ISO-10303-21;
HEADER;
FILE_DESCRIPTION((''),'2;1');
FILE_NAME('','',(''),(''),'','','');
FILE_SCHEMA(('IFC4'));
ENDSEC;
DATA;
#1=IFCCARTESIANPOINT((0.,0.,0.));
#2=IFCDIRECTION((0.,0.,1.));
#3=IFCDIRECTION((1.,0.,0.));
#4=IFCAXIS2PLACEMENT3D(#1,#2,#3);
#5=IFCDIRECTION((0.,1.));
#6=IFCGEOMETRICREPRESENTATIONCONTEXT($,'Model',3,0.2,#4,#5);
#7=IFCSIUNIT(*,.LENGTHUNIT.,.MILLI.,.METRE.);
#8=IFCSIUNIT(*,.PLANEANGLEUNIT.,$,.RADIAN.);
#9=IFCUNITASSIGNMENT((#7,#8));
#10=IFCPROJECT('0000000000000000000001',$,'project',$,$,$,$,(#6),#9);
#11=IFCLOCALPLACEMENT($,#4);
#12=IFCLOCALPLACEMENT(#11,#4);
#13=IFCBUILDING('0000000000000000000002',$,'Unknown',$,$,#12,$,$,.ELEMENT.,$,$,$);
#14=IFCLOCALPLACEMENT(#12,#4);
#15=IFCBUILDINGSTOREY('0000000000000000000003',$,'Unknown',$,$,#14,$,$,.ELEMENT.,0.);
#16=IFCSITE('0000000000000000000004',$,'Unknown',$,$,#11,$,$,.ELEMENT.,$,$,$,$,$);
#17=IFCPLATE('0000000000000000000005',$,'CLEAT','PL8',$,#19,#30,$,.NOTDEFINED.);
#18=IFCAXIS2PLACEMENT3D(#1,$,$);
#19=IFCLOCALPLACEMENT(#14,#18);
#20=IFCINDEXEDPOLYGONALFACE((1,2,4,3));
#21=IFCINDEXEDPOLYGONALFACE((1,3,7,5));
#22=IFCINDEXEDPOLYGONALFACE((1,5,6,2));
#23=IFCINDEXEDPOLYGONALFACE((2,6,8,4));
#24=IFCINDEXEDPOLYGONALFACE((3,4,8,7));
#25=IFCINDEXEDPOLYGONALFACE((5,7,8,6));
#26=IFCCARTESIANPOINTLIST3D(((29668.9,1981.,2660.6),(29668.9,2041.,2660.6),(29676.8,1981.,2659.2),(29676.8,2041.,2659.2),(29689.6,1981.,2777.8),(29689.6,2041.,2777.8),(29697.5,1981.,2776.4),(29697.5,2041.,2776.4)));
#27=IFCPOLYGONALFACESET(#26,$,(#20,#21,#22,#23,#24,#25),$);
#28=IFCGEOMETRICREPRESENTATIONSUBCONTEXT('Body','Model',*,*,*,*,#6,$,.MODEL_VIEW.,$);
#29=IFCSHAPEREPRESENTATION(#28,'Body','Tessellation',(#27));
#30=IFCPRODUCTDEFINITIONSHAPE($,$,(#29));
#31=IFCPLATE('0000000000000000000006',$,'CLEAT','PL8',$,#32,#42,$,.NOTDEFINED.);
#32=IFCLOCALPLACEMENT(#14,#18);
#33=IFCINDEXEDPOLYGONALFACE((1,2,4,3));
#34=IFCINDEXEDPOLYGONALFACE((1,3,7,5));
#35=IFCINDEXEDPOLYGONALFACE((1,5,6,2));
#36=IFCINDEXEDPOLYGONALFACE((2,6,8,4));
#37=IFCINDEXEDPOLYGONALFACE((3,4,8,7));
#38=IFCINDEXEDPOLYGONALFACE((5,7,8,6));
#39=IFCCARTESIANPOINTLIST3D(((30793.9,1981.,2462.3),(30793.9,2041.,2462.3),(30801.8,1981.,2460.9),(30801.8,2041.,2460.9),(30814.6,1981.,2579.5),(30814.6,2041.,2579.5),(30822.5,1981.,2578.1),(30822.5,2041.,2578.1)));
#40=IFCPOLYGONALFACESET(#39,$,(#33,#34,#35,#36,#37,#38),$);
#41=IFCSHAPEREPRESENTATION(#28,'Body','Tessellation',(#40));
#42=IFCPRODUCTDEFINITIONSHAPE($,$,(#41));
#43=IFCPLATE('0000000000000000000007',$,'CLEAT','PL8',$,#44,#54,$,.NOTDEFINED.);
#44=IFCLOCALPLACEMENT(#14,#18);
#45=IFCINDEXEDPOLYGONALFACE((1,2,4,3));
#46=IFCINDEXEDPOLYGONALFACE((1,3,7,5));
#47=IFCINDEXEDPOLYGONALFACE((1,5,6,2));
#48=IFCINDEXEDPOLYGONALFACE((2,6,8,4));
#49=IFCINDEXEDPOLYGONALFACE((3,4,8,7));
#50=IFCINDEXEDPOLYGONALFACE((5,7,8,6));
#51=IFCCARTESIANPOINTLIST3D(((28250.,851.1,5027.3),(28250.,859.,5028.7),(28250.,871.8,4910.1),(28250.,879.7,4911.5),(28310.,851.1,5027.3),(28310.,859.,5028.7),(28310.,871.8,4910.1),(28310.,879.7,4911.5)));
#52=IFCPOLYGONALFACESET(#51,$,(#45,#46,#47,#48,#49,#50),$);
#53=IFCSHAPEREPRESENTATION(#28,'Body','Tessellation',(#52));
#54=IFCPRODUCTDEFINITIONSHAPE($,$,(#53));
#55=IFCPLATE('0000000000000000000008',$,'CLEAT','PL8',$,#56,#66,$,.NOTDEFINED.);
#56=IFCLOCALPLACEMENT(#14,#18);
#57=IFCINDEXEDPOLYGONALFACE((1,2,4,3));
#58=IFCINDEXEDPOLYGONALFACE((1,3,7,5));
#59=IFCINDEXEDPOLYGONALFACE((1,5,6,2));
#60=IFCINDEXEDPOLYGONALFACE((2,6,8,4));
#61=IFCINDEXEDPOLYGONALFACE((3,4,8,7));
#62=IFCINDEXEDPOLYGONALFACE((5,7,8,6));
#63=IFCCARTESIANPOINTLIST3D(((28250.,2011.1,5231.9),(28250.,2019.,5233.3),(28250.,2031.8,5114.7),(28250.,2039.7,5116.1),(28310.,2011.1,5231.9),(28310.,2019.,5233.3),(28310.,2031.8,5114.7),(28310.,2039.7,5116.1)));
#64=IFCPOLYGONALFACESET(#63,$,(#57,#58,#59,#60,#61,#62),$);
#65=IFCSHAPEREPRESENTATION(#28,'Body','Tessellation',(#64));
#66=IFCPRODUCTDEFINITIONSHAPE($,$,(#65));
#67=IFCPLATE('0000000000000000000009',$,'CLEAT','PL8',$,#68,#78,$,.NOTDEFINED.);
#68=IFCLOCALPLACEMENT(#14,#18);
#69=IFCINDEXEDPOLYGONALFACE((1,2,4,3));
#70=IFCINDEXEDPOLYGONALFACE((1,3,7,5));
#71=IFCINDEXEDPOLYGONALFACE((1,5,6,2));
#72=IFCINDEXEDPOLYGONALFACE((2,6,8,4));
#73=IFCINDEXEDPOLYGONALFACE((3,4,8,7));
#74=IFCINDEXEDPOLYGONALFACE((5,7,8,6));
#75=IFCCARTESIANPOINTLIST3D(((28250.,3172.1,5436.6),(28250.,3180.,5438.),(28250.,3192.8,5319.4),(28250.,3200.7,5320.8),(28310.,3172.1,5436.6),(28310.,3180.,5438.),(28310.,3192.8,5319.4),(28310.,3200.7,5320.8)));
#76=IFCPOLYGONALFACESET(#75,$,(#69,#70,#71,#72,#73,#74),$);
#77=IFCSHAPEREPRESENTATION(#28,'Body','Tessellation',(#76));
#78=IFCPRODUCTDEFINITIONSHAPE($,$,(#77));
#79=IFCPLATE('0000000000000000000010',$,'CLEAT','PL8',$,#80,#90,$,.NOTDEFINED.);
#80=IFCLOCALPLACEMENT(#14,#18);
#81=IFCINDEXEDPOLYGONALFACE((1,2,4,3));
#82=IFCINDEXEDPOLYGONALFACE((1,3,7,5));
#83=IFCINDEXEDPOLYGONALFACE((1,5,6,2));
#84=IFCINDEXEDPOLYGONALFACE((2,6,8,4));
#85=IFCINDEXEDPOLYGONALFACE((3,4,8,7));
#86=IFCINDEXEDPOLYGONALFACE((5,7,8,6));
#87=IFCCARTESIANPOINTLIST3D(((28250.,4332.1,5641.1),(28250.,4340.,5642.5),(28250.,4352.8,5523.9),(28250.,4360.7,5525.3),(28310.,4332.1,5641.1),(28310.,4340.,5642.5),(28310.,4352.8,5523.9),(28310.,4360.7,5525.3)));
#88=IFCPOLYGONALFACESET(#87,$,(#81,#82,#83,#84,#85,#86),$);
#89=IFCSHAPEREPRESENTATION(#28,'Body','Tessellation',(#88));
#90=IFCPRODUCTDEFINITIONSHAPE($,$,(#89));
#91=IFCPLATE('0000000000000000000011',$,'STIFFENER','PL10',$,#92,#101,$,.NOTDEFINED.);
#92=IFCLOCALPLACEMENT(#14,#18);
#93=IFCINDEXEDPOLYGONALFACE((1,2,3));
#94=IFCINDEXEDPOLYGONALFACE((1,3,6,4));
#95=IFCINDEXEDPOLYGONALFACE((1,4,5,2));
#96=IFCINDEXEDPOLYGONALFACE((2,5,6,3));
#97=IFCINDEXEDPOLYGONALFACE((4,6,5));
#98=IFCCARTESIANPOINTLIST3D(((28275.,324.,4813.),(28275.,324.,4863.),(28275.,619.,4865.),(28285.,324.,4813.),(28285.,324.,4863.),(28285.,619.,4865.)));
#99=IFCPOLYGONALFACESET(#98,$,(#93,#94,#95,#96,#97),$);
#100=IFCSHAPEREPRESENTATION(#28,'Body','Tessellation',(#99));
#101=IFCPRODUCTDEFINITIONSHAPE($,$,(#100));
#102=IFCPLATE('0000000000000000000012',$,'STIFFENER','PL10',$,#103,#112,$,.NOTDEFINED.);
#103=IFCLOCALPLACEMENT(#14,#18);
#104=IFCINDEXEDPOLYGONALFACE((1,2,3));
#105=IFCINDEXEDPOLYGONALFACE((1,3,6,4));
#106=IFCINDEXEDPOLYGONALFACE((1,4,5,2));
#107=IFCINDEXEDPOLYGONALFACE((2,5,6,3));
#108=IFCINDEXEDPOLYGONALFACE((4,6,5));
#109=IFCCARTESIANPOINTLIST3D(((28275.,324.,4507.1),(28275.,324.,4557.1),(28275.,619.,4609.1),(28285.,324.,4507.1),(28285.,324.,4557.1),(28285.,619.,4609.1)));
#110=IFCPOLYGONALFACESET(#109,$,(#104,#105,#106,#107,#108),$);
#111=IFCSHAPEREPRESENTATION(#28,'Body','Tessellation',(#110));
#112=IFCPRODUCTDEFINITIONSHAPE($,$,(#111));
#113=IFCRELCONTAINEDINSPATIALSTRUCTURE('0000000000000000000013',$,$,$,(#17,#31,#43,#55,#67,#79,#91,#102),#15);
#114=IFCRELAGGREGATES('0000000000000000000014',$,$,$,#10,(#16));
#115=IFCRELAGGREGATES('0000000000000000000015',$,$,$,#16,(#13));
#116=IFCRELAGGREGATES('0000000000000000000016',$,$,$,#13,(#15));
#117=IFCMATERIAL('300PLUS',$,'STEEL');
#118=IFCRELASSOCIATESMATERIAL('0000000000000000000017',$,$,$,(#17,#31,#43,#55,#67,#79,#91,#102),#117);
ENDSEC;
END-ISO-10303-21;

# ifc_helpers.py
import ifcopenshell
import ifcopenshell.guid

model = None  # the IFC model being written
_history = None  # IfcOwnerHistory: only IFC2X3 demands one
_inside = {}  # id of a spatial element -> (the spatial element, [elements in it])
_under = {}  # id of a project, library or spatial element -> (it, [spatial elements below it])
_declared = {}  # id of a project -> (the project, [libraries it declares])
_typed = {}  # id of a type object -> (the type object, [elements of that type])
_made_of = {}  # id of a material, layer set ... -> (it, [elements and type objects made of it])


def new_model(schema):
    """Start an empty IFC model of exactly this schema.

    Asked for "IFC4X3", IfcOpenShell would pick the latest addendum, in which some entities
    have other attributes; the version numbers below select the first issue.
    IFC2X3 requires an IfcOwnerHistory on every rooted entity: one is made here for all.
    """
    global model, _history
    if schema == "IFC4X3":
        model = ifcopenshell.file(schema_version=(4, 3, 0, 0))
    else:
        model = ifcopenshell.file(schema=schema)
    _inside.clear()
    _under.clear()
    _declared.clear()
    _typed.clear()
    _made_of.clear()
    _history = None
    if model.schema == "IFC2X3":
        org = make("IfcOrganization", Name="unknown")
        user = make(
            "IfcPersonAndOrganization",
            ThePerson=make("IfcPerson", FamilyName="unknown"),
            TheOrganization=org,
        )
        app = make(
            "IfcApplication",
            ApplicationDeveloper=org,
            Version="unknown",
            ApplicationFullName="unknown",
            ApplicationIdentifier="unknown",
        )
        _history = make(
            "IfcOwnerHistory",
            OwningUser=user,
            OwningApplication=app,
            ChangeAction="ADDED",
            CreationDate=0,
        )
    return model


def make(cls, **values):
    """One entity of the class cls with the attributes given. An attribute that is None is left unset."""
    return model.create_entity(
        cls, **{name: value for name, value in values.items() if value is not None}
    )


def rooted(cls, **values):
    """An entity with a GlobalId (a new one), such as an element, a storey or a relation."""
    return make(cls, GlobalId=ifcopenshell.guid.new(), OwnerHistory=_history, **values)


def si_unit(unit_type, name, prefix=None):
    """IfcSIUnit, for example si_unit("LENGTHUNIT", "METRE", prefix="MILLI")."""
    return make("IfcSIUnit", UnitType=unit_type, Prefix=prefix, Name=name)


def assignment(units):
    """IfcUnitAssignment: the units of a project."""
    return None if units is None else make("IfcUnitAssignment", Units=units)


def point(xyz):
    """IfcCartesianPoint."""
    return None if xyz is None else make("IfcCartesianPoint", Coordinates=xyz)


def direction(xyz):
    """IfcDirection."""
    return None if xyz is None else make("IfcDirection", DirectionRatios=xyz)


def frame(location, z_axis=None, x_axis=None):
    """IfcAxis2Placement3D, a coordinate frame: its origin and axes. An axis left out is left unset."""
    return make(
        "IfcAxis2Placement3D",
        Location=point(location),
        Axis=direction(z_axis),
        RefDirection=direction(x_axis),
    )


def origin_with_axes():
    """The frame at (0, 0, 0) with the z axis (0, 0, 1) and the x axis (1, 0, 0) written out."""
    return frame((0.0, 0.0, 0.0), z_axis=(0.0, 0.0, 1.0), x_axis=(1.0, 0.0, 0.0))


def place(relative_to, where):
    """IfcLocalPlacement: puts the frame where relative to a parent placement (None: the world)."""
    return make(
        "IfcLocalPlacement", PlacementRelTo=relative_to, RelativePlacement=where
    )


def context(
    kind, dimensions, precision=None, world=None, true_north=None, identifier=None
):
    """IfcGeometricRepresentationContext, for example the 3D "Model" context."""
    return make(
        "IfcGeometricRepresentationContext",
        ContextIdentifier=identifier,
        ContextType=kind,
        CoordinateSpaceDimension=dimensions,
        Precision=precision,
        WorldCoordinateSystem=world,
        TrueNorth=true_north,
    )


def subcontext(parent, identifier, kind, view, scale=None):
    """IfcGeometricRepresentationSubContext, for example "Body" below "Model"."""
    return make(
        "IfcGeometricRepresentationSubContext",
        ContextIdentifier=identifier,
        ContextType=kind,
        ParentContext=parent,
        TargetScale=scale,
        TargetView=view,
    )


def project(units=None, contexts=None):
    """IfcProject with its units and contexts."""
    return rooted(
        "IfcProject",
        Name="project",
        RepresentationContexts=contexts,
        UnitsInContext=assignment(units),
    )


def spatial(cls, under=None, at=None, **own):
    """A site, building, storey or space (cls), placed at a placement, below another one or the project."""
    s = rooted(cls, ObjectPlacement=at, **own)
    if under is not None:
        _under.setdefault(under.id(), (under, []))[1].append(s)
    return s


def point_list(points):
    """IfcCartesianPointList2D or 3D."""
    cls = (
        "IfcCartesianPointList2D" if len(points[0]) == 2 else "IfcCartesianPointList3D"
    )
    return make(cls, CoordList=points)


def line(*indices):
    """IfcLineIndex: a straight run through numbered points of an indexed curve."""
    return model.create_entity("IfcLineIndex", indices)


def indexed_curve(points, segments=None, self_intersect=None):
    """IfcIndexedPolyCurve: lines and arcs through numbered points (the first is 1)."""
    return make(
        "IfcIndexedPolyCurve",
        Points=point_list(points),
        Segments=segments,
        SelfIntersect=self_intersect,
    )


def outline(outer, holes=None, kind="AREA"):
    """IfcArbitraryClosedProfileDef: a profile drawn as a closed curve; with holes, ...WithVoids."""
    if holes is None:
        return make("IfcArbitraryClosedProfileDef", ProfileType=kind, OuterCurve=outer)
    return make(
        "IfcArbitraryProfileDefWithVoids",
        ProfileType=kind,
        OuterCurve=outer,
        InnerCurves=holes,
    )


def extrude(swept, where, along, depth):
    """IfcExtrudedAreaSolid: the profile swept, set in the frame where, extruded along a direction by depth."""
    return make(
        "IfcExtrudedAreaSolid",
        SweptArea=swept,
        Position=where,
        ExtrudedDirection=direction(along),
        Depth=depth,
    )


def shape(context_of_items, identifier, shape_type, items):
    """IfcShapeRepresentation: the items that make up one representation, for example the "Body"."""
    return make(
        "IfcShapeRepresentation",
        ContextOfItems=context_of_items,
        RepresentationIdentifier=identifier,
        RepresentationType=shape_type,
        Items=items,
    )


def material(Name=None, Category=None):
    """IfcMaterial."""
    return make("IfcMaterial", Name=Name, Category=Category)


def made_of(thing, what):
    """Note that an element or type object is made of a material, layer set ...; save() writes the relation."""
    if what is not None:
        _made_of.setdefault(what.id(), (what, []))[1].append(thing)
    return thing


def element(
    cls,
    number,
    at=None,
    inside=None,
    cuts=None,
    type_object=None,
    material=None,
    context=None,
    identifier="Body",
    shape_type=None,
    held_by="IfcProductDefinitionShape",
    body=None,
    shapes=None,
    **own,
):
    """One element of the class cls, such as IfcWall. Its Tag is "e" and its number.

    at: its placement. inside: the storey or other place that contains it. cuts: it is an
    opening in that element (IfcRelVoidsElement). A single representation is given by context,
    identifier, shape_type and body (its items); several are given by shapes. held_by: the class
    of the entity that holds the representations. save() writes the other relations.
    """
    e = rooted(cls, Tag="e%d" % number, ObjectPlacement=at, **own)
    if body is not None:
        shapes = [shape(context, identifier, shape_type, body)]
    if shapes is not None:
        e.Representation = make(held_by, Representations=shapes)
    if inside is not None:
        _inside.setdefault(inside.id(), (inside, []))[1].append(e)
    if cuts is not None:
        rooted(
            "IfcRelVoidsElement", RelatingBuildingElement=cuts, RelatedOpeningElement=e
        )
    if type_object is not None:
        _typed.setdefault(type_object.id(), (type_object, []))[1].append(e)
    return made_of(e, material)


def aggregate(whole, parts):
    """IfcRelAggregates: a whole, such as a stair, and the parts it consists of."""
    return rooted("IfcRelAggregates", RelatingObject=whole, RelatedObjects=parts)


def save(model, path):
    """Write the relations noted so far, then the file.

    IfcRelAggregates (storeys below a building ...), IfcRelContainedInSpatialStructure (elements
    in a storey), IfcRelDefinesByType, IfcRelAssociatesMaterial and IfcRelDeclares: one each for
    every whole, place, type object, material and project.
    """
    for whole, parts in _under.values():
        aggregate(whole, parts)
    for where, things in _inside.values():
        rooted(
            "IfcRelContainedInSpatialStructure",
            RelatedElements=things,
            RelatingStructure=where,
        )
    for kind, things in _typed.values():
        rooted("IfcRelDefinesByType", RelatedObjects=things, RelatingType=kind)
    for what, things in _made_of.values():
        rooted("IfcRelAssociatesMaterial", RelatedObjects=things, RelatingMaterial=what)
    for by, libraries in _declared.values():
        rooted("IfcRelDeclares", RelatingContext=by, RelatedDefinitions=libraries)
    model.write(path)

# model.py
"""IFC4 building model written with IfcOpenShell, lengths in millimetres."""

from ifc_helpers import new_model, si_unit, direction, frame, origin_with_axes, place, context, subcontext, project, spatial, line, indexed_curve, outline, extrude, material, element, save


model = new_model("IFC4")

# Units and contexts
model_context = context("Model", 3, precision=0.2, world=origin_with_axes(), true_north=direction((0.0, 1.0)))
body_context = subcontext(model_context, "Body", "Model", "MODEL_VIEW")
ifc_project = project(units=[si_unit("LENGTHUNIT", "METRE", prefix="MILLI"), si_unit("PLANEANGLEUNIT", "RADIAN")], contexts=[model_context])

# Site, building, storey
site_placement = place(None, origin_with_axes())
site = spatial("IfcSite", under=ifc_project, at=site_placement, Name="Unknown", CompositionType="ELEMENT")
building_placement = place(site_placement, origin_with_axes())
building = spatial("IfcBuilding", under=site, at=building_placement, Name="Unknown", CompositionType="ELEMENT")
storey_placement = place(building_placement, origin_with_axes())
storey = spatial("IfcBuildingStorey", under=building, at=storey_placement, Name="Unknown", CompositionType="ELEMENT", Elevation=0.0)

# Shared definitions
ifc_material_1 = material(Name="300PLUS", Category="STEEL")

# Plates
for number, where, z_axis, x_axis, name in (
    (1, (29672.9, 2041.0, 2659.9), (-0.984758, 0.0, 0.173929), (0.0, -1.0, 0.0), "CLEAT"),
    (2, (30797.9, 2041.0, 2461.6), (-0.984758, 0.0, 0.173929), (0.0, -1.0, 0.0), "CLEAT"),
    (3, (28310.0, 875.7, 4910.8), (0.0, 0.984758, 0.173929), (-1.0, 0.0, 0.0), "CLEAT"),
    (4, (28310.0, 2035.7, 5115.4), (0.0, 0.984758, 0.173929), (-1.0, 0.0, 0.0), "CLEAT"),
    (5, (28310.0, 3196.7, 5320.1), (0.0, 0.984758, 0.173929), (-1.0, 0.0, 0.0), "CLEAT"),
    (6, (28310.0, 4356.7, 5524.6), (0.0, 0.984758, 0.173929), (-1.0, 0.0, 0.0), "CLEAT"),
):
    element("IfcPlate", number, at=place(storey_placement, frame(where, z_axis=z_axis, x_axis=x_axis)), inside=storey, material=ifc_material_1, Name=name, Description="PL8", PredefinedType="NOTDEFINED", context=body_context, shape_type="SolidModel", body=[
        extrude(outline(indexed_curve([(0.0, 0.0), (60.0, 0.0), (60.0, 119.0), (0.0, 119.0)], segments=[line(1, 2, 3, 4, 1)])), frame((0.0, 0.0, 4.0), z_axis=(0.0, 0.0, 1.0), x_axis=(1.0, 0.0, 0.0)), (0.0, 0.0, -1.0), 8.0),
    ])
plate_1_placement = place(storey_placement, frame((28280.0, 619.0, 4865.0), z_axis=(1.0, 0.0, 0.0), x_axis=(0.0, -0.999977, -0.00678)))
element("IfcPlate", 7, at=plate_1_placement, inside=storey, material=ifc_material_1, Name="STIFFENER", Description="PL10", PredefinedType="NOTDEFINED", context=body_context, shape_type="SolidModel", body=[
    extrude(outline(indexed_curve([(0.0, 0.0), (295.0, 0.0), (295.3, 50.0)], segments=[line(1, 2, 3, 1)])), frame((0.0, 0.0, 5.0), z_axis=(0.0, 0.0, 1.0), x_axis=(1.0, 0.0, 0.0)), (0.0, 0.0, -1.0), 10.0),
])
plate_2_placement = place(storey_placement, frame((28280.0, 619.0, 4609.1), z_axis=(1.0, 0.0, 0.0), x_axis=(0.0, -0.984817, -0.173595)))
element("IfcPlate", 8, at=plate_2_placement, inside=storey, material=ifc_material_1, Name="STIFFENER", Description="PL10", PredefinedType="NOTDEFINED", context=body_context, shape_type="SolidModel", body=[
    extrude(outline(indexed_curve([(0.0, 0.0), (299.5, 0.0), (308.2, 49.2)], segments=[line(1, 2, 3, 1)])), frame((0.0, 0.0, 5.0), z_axis=(0.0, 0.0, 1.0), x_axis=(1.0, 0.0, 0.0)), (0.0, 0.0, -1.0), 10.0),
])

save(model, "model.ifc")
